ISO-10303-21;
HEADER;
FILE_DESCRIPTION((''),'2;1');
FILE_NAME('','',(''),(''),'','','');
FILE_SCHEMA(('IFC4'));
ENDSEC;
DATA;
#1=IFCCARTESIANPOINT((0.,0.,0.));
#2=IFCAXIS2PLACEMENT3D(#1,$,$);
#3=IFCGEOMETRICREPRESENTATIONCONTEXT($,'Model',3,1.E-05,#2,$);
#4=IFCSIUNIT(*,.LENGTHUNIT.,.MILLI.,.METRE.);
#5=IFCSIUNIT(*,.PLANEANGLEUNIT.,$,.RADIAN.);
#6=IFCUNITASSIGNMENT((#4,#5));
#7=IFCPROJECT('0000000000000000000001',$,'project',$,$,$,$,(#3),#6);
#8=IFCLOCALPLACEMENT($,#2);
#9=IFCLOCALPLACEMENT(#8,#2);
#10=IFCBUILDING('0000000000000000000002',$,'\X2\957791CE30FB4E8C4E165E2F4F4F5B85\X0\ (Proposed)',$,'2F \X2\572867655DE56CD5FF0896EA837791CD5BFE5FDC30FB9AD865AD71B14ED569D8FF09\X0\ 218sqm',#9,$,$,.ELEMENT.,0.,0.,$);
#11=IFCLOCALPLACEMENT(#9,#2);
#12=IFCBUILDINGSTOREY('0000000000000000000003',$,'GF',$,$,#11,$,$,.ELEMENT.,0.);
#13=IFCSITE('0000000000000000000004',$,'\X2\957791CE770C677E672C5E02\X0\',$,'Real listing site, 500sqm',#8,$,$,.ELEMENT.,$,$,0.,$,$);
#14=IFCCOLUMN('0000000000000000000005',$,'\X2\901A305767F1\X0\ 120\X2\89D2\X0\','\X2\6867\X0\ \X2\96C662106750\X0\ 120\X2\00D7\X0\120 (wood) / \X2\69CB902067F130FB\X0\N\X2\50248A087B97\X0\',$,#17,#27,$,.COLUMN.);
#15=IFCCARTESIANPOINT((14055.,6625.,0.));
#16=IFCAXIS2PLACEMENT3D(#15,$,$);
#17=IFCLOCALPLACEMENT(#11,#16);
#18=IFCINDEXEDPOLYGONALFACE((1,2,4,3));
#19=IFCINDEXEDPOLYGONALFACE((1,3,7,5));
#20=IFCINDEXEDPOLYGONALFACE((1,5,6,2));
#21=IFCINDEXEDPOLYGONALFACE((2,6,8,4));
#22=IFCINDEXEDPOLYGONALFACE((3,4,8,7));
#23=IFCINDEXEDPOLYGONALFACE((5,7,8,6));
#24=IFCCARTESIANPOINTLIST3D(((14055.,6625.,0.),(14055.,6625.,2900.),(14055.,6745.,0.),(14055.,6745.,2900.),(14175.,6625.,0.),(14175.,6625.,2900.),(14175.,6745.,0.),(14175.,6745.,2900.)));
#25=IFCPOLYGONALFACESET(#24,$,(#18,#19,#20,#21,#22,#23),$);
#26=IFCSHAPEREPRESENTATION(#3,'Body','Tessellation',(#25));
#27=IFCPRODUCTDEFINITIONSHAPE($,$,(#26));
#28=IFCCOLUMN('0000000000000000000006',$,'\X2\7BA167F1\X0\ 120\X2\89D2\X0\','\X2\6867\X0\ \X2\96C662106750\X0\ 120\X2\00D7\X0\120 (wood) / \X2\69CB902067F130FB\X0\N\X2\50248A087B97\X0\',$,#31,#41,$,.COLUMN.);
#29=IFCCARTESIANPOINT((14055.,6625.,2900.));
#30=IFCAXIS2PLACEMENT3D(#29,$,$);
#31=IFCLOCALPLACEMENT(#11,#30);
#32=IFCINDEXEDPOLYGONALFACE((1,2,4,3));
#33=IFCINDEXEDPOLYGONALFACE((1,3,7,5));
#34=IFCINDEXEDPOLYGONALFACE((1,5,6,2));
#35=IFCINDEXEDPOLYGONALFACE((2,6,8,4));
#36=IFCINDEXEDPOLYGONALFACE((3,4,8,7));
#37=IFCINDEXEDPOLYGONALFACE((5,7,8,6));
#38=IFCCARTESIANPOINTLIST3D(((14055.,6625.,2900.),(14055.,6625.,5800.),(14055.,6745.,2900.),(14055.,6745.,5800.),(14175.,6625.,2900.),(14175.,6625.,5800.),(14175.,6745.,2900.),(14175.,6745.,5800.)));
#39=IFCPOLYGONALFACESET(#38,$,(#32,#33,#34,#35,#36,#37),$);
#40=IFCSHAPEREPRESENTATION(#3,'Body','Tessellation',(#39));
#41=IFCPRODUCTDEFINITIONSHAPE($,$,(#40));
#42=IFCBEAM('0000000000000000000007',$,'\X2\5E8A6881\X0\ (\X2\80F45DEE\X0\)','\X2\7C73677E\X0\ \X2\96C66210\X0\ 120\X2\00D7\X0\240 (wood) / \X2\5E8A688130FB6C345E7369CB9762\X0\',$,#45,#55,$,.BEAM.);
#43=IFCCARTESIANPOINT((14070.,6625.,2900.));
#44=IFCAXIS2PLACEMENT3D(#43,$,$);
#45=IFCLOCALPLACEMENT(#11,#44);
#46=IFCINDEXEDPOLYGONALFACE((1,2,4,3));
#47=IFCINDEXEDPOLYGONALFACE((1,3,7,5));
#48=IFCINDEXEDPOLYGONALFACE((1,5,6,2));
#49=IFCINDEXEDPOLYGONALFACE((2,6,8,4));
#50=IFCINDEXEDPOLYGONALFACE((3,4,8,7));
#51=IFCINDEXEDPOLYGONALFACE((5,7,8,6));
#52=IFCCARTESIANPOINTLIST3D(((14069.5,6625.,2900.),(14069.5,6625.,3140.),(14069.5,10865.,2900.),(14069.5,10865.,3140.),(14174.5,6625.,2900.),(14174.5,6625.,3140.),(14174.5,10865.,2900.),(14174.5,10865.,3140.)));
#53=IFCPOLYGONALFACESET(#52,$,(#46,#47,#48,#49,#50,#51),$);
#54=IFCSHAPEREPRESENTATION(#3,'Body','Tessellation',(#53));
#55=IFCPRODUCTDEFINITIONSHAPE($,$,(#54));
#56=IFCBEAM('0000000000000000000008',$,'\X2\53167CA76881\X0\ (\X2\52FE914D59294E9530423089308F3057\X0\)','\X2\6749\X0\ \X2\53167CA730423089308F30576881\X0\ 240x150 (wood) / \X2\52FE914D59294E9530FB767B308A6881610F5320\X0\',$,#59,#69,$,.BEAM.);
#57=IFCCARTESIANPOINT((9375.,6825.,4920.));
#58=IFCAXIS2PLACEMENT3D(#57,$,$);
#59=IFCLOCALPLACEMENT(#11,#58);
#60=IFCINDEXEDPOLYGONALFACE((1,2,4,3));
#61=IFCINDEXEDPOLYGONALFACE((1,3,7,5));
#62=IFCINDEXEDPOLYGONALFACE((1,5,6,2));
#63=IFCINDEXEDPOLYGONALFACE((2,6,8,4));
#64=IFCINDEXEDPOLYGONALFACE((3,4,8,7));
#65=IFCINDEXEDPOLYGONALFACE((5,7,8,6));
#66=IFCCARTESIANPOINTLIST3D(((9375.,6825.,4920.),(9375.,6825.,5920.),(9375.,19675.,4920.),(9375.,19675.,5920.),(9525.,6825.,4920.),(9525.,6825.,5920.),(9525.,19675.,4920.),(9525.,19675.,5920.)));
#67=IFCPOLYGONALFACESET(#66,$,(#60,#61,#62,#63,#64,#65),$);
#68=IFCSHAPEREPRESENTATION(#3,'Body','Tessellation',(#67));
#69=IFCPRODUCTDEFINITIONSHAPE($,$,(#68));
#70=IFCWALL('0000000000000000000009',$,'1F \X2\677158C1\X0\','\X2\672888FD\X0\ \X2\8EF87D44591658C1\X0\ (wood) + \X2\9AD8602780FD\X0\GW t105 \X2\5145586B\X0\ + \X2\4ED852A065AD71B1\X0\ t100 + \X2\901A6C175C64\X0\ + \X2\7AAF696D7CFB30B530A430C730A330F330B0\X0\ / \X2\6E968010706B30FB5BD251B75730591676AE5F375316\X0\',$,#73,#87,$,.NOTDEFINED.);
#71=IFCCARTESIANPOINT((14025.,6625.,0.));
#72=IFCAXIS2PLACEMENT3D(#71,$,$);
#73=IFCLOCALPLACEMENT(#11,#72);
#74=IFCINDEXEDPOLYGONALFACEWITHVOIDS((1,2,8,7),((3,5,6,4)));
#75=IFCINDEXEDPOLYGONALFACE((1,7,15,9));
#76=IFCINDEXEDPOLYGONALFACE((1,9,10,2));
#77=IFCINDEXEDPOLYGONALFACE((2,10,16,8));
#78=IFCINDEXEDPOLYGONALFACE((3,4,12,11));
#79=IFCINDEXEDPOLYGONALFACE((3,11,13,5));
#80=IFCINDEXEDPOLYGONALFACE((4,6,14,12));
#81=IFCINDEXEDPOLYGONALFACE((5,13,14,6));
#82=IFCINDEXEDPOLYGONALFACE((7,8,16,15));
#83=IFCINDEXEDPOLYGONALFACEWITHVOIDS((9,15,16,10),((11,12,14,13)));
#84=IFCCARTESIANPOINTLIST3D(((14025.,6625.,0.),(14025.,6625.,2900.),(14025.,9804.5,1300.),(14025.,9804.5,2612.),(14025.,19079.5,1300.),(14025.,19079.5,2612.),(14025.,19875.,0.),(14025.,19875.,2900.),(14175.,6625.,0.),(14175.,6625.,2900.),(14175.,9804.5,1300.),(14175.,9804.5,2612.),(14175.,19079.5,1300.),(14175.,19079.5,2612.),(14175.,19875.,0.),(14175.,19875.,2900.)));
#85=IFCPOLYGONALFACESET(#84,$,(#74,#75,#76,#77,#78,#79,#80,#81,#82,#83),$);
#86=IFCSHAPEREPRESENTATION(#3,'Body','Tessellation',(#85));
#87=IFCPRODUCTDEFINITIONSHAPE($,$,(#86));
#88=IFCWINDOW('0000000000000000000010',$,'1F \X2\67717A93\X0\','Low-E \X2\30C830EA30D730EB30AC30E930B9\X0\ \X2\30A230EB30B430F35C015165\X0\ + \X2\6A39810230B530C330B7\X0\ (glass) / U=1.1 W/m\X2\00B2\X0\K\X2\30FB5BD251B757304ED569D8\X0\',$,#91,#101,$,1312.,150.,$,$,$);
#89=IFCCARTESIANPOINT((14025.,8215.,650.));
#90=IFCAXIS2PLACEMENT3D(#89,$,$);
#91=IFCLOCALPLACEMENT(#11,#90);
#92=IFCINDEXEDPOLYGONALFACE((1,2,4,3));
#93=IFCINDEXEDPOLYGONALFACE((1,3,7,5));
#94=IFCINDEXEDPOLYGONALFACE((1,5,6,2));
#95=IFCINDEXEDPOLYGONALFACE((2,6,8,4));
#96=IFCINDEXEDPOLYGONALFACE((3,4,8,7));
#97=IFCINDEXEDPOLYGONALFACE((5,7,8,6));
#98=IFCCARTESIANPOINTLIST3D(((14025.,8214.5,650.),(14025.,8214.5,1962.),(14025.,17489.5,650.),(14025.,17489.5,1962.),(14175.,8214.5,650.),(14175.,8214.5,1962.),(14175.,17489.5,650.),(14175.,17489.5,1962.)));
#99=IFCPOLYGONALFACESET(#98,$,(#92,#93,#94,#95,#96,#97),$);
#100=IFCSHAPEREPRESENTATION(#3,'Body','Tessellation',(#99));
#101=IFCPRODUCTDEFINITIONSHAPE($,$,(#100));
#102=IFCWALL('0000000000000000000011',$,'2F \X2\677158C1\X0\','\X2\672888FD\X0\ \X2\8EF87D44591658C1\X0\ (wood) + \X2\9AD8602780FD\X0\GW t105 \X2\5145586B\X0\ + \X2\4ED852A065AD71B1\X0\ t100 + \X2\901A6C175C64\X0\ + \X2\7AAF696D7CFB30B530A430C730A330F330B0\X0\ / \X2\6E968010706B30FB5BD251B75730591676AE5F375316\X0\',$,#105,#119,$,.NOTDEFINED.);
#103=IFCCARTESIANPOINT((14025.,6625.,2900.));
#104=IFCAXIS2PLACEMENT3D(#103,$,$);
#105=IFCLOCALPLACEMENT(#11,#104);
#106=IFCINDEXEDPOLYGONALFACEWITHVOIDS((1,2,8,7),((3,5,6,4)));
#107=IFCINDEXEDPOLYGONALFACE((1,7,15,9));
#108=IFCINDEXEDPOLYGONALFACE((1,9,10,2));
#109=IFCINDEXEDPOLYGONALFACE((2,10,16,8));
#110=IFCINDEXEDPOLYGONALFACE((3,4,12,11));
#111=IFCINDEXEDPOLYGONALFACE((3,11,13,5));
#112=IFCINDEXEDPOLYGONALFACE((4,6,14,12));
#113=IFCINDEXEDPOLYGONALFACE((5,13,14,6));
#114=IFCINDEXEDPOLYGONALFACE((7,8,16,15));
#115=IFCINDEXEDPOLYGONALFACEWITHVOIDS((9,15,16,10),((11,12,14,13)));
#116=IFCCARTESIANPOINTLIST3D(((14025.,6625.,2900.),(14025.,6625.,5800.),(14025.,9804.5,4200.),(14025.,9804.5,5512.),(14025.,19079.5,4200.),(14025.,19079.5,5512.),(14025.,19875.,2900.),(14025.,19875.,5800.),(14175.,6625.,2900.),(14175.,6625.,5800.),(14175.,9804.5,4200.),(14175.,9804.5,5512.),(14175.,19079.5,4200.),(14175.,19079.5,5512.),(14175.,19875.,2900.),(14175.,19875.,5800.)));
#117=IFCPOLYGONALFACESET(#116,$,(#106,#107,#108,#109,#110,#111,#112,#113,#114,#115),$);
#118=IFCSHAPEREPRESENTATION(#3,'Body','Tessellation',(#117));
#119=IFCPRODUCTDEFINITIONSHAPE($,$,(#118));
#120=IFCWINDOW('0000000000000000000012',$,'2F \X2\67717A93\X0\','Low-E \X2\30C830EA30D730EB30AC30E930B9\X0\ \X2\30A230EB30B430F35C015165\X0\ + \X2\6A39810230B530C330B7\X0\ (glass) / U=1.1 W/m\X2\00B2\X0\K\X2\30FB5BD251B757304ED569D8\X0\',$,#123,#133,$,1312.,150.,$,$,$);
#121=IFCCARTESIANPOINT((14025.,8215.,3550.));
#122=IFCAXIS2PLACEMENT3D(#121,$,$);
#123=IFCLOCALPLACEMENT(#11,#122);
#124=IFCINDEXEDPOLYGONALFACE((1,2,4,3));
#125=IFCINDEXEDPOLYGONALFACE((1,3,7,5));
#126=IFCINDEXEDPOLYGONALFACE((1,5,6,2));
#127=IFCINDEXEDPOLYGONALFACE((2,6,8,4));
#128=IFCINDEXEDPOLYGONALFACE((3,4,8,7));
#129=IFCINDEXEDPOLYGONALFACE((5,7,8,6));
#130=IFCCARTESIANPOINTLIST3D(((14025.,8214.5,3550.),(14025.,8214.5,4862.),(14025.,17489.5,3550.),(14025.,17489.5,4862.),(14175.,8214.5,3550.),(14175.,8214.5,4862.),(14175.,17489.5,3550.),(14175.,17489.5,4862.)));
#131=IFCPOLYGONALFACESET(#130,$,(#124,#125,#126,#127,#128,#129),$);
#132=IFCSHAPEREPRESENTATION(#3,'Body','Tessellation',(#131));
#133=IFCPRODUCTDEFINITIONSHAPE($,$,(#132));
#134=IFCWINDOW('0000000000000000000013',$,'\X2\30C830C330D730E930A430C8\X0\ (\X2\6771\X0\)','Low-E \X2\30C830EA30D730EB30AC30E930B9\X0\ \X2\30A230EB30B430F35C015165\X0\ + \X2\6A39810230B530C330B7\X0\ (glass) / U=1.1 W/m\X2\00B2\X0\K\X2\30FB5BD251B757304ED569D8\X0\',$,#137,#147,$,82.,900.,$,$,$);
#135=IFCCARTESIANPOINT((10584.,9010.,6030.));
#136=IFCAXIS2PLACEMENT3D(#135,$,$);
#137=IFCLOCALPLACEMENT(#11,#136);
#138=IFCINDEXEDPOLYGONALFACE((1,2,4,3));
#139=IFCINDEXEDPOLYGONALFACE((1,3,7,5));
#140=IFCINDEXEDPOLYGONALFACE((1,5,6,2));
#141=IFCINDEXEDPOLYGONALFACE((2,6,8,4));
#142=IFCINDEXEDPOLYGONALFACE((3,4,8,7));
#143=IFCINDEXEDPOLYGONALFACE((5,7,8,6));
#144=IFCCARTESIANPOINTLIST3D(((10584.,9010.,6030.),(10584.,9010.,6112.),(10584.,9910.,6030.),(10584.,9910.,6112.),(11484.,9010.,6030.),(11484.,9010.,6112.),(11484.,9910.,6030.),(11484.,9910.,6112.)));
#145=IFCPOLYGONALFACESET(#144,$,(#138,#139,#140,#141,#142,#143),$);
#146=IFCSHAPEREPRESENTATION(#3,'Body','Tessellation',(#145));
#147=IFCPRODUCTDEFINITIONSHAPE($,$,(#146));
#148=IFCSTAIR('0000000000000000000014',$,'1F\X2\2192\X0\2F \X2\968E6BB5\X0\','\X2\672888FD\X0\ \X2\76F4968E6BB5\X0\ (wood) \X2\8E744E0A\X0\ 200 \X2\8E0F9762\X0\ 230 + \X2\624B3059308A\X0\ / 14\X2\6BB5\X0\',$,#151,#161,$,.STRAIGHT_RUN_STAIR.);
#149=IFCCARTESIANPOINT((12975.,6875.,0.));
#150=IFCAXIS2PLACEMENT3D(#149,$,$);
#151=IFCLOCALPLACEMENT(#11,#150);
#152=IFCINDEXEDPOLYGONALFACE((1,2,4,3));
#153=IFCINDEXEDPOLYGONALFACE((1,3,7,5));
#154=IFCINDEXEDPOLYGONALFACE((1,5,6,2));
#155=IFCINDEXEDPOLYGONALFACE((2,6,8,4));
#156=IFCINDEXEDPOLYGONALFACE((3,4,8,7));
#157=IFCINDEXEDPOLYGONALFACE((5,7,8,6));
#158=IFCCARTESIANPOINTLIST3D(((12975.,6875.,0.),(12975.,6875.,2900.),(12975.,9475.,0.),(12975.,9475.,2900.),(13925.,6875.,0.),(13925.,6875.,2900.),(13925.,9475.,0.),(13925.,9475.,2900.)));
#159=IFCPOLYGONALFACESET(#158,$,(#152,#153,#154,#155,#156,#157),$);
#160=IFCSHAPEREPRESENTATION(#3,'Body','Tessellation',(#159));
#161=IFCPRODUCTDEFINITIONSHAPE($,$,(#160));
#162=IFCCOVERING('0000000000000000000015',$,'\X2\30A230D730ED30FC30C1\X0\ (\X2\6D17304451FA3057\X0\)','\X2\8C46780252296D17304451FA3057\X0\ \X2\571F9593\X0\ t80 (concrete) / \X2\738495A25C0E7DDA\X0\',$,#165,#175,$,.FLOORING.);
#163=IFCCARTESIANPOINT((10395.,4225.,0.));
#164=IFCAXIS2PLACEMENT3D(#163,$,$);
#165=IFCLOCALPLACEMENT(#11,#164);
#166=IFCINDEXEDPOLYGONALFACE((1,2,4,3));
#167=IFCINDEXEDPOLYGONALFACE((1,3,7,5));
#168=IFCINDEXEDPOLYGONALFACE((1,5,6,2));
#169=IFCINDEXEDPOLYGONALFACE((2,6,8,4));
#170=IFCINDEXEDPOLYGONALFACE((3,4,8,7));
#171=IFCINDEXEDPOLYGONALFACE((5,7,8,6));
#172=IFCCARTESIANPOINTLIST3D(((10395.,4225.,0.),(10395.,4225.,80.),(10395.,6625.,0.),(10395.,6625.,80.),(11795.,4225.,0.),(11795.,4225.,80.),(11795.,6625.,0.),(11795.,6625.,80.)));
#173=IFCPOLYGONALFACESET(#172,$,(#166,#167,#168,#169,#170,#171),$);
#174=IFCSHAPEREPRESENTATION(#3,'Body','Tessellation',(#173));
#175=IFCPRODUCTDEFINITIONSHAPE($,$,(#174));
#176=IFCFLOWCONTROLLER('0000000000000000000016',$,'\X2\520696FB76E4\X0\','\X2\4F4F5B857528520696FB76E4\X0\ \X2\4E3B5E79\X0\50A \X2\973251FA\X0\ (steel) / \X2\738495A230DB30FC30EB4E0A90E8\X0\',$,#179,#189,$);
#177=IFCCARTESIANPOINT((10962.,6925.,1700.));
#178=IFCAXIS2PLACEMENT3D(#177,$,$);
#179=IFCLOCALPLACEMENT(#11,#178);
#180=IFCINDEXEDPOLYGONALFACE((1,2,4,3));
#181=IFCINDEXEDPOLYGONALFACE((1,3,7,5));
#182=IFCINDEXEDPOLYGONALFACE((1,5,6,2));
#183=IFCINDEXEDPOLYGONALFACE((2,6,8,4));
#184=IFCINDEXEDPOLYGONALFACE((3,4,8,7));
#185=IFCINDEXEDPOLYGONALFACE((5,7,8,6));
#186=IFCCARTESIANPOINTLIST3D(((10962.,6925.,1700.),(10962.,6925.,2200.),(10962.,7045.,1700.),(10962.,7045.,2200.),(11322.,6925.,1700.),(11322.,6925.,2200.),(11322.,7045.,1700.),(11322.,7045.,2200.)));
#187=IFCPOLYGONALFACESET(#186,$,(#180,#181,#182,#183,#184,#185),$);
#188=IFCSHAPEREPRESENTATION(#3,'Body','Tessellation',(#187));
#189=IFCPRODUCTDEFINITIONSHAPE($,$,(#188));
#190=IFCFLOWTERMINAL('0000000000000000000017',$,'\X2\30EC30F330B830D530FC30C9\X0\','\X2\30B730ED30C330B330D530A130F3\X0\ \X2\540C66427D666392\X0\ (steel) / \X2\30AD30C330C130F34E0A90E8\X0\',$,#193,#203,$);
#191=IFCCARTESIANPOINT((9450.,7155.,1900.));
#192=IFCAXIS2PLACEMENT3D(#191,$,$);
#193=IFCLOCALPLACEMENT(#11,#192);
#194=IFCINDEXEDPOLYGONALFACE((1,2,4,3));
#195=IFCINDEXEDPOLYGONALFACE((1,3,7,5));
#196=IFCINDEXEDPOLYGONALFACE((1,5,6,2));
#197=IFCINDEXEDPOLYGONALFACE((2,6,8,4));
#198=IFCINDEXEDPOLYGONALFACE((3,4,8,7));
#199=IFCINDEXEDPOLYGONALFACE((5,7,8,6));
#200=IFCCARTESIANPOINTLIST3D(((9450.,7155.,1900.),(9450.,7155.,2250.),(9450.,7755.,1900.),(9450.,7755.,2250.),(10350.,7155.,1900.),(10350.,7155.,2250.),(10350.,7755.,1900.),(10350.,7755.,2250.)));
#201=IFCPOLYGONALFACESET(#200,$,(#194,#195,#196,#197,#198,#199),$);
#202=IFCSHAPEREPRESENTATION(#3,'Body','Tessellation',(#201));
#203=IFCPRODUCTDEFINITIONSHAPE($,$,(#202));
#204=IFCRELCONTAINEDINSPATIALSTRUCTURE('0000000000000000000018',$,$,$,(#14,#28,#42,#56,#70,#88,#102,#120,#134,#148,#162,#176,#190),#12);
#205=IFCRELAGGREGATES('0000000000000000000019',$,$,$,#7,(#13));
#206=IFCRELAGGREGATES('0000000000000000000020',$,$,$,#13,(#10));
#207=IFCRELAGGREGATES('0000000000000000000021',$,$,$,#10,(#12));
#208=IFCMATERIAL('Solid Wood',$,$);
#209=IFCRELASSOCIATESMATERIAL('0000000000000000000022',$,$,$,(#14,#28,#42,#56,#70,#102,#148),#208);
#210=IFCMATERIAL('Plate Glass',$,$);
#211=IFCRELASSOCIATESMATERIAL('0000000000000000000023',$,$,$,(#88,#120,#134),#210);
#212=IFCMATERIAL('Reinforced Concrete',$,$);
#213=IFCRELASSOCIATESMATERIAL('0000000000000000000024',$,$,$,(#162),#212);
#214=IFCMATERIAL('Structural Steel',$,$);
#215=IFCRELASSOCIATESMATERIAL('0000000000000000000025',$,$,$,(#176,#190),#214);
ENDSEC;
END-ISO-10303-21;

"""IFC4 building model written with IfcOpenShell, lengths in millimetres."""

from ifc_helpers import new_model, si_unit, frame, frame_2d, origin, place, context, project, spatial, rectangle, extrude, material, element, fill, save


model = new_model("IFC4")

# Units and contexts
model_context = context("Model", 3, precision=1e-05, world=origin())
ifc_project = project(units=[si_unit("LENGTHUNIT", "METRE", prefix="MILLI"), si_unit("PLANEANGLEUNIT", "RADIAN")], contexts=[model_context])

# Site, building, storey
site_placement = place(None, origin())
site = spatial("IfcSite", under=ifc_project, at=site_placement, Name="長野県松本市", ObjectType="Real listing site, 500sqm", CompositionType="ELEMENT", RefElevation=0.0)
building_placement = place(site_placement, origin())
building = spatial("IfcBuilding", under=site, at=building_placement, Name="長野・二世帯住宅 (Proposed)", ObjectType="2F 在来工法（雪荷重対応・高断熱仕様） 218sqm", CompositionType="ELEMENT", ElevationOfRefHeight=0.0, ElevationOfTerrain=0.0)
storey_placement = place(building_placement, origin())
storey = spatial("IfcBuildingStorey", under=building, at=storey_placement, Name="GF", CompositionType="ELEMENT", Elevation=0.0)

# Columns
ifc_material_1 = material(Name="Solid Wood")
column_1_placement = place(storey_placement, frame((14055.0, 6625.0, 0.0)))
element("IfcColumn", 1, at=column_1_placement, inside=storey, material=ifc_material_1, Name="通し柱 120角", Description="桧 集成材 120×120 (wood) / 構造柱・N値計算", PredefinedType="COLUMN", context=model_context, shape_type="SweptSolid", body=[
    extrude(rectangle(XDim=120.0, YDim=120.0, at=frame_2d((60.0, 60.0))), frame((14055.0, 6625.0, 0.0)), (0.0, 0.0, 1.0), 2900.0),
])
column_2_placement = place(storey_placement, frame((14055.0, 6625.0, 2900.0)))
element("IfcColumn", 2, at=column_2_placement, inside=storey, material=ifc_material_1, Name="管柱 120角", Description="桧 集成材 120×120 (wood) / 構造柱・N値計算", PredefinedType="COLUMN", context=model_context, shape_type="SweptSolid", body=[
    extrude(rectangle(XDim=120.0, YDim=120.0, at=frame_2d((60.0, 60.0))), frame((14055.0, 6625.0, 2900.0)), (0.0, 0.0, 1.0), 2900.0),
])

# Beams
beam_1_placement = place(storey_placement, frame((14070.0, 6625.0, 2900.0)))
element("IfcBeam", 3, at=beam_1_placement, inside=storey, material=ifc_material_1, Name="床梁 (胴差)", Description="米松 集成 120×240 (wood) / 床梁・水平構面", PredefinedType="BEAM", context=model_context, shape_type="SweptSolid", body=[
    extrude(rectangle(XDim=105.0, YDim=4240.0, at=frame_2d((52.0, 2120.0))), frame((14070.0, 6625.0, 2900.0)), (0.0, 0.0, 1.0), 240.0),
])
beam_2_placement = place(storey_placement, frame((9375.0, 6825.0, 4920.0)))
element("IfcBeam", 4, at=beam_2_placement, inside=storey, material=ifc_material_1, Name="化粧梁 (勾配天井あらわし)", Description="杉 化粧あらわし梁 240x150 (wood) / 勾配天井・登り梁意匠", PredefinedType="BEAM", context=model_context, shape_type="SweptSolid", body=[
    extrude(rectangle(XDim=150.0, YDim=12850.0, at=frame_2d((75.0, 6425.0))), frame((9375.0, 6825.0, 4920.0)), (0.0, 0.0, 1.0), 1000.0),
])

# Wall, opening, window
wall_1_placement = place(storey_placement, frame((14025.0, 6625.0, 0.0)))
wall_1 = element("IfcWall", 5, at=wall_1_placement, inside=storey, material=ifc_material_1, Name="1F 東壁", Description="木製 軸組外壁 (wood) + 高性能GW t105 充填 + 付加断熱 t100 + 通気層 + 窯業系サイディング / 準耐火・寒冷地外皮強化", PredefinedType="NOTDEFINED", context=model_context, shape_type="SweptSolid", body=[
    extrude(rectangle(XDim=150.0, YDim=13250.0, at=frame_2d((75.0, 6625.0))), frame((14025.0, 6625.0, 0.0)), (0.0, 0.0, 1.0), 2900.0),
])
opening_1_placement = place(storey_placement, frame((14025.0, 8215.0, 650.0)))
opening_1 = element("IfcOpeningElement", 6, at=opening_1_placement, cuts=wall_1, PredefinedType="NOTDEFINED", context=model_context, shape_type="SweptSolid", body=[
    extrude(rectangle(XDim=150.0, YDim=9275.0, at=frame_2d((75.0, 4637.0))), frame((14025.0, 8215.0, 650.0)), (0.0, 0.0, 1.0), 1312.0),
])
ifc_material_2 = material(Name="Plate Glass")
window_1_placement = place(storey_placement, frame((14025.0, 8215.0, 650.0)))
window_1 = element("IfcWindow", 7, at=window_1_placement, inside=storey, material=ifc_material_2, Name="1F 東窓", Description="Low-E トリプルガラス アルゴン封入 + 樹脂サッシ (glass) / U=1.1 W/m²K・寒冷地仕様", OverallHeight=1312.0, OverallWidth=150.0, context=model_context, shape_type="SweptSolid", body=[
    extrude(rectangle(XDim=150.0, YDim=9275.0, at=frame_2d((75.0, 4637.0))), frame((14025.0, 8215.0, 650.0)), (0.0, 0.0, 1.0), 1312.0),
])
fill(opening_1, window_1)

# Wall, opening, window
wall_2_placement = place(storey_placement, frame((14025.0, 6625.0, 2900.0)))
wall_2 = element("IfcWall", 8, at=wall_2_placement, inside=storey, material=ifc_material_1, Name="2F 東壁", Description="木製 軸組外壁 (wood) + 高性能GW t105 充填 + 付加断熱 t100 + 通気層 + 窯業系サイディング / 準耐火・寒冷地外皮強化", PredefinedType="NOTDEFINED", context=model_context, shape_type="SweptSolid", body=[
    extrude(rectangle(XDim=150.0, YDim=13250.0, at=frame_2d((75.0, 6625.0))), frame((14025.0, 6625.0, 2900.0)), (0.0, 0.0, 1.0), 2900.0),
])
opening_2_placement = place(storey_placement, frame((14025.0, 8215.0, 3550.0)))
opening_2 = element("IfcOpeningElement", 9, at=opening_2_placement, cuts=wall_2, PredefinedType="NOTDEFINED", context=model_context, shape_type="SweptSolid", body=[
    extrude(rectangle(XDim=150.0, YDim=9275.0, at=frame_2d((75.0, 4637.0))), frame((14025.0, 8215.0, 3550.0)), (0.0, 0.0, 1.0), 1312.0),
])
window_2_placement = place(storey_placement, frame((14025.0, 8215.0, 3550.0)))
window_2 = element("IfcWindow", 10, at=window_2_placement, inside=storey, material=ifc_material_2, Name="2F 東窓", Description="Low-E トリプルガラス アルゴン封入 + 樹脂サッシ (glass) / U=1.1 W/m²K・寒冷地仕様", OverallHeight=1312.0, OverallWidth=150.0, context=model_context, shape_type="SweptSolid", body=[
    extrude(rectangle(XDim=150.0, YDim=9275.0, at=frame_2d((75.0, 4637.0))), frame((14025.0, 8215.0, 3550.0)), (0.0, 0.0, 1.0), 1312.0),
])
fill(opening_2, window_2)

# Window
window_3_placement = place(storey_placement, frame((10584.0, 9010.0, 6030.0)))
element("IfcWindow", 11, at=window_3_placement, inside=storey, material=ifc_material_2, Name="トップライト (東)", Description="Low-E トリプルガラス アルゴン封入 + 樹脂サッシ (glass) / U=1.1 W/m²K・寒冷地仕様", OverallHeight=82.0, OverallWidth=900.0, context=model_context, shape_type="SweptSolid", body=[
    extrude(rectangle(XDim=900.0, YDim=900.0, at=frame_2d((450.0, 450.0))), frame((10584.0, 9010.0, 6030.0)), (0.0, 0.0, 1.0), 82.0),
])

# Stair
stair_placement = place(storey_placement, frame((12975.0, 6875.0, 0.0)))
element("IfcStair", 12, at=stair_placement, inside=storey, material=ifc_material_1, Name="1F→2F 階段", Description="木製 直階段 (wood) 蹴上 200 踏面 230 + 手すり / 14段", PredefinedType="STRAIGHT_RUN_STAIR", context=model_context, shape_type="SweptSolid", body=[
    extrude(rectangle(XDim=950.0, YDim=2600.0, at=frame_2d((475.0, 1300.0))), frame((12975.0, 6875.0, 0.0)), (0.0, 0.0, 1.0), 2900.0),
])

# Covering
ifc_material_3 = material(Name="Reinforced Concrete")
covering_placement = place(storey_placement, frame((10395.0, 4225.0, 0.0)))
element("IfcCovering", 13, at=covering_placement, inside=storey, material=ifc_material_3, Name="アプローチ (洗い出し)", Description="豆砂利洗い出し 土間 t80 (concrete) / 玄関導線", PredefinedType="FLOORING", context=model_context, shape_type="SweptSolid", body=[
    extrude(rectangle(XDim=1400.0, YDim=2400.0, at=frame_2d((700.0, 1200.0))), frame((10395.0, 4225.0, 0.0)), (0.0, 0.0, 1.0), 80.0),
])

# Flow controller
ifc_material_4 = material(Name="Structural Steel")
flow_controller_placement = place(storey_placement, frame((10962.0, 6925.0, 1700.0)))
element("IfcFlowController", 14, at=flow_controller_placement, inside=storey, material=ifc_material_4, Name="分電盤", Description="住宅用分電盤 主幹50A 露出 (steel) / 玄関ホール上部", context=model_context, shape_type="SweptSolid", body=[
    extrude(rectangle(XDim=360.0, YDim=120.0, at=frame_2d((180.0, 60.0))), frame((10962.0, 6925.0, 1700.0)), (0.0, 0.0, 1.0), 500.0),
])

# Flow terminal
flow_terminal_1_placement = place(storey_placement, frame((9450.0, 7155.0, 1900.0)))
element("IfcFlowTerminal", 15, at=flow_terminal_1_placement, inside=storey, material=ifc_material_4, Name="レンジフード", Description="シロッコファン 同時給排 (steel) / キッチン上部", context=model_context, shape_type="SweptSolid", body=[
    extrude(rectangle(XDim=900.0, YDim=600.0, at=frame_2d((450.0, 300.0))), frame((9450.0, 7155.0, 1900.0)), (0.0, 0.0, 1.0), 350.0),
])

save(model, "model.ifc")
